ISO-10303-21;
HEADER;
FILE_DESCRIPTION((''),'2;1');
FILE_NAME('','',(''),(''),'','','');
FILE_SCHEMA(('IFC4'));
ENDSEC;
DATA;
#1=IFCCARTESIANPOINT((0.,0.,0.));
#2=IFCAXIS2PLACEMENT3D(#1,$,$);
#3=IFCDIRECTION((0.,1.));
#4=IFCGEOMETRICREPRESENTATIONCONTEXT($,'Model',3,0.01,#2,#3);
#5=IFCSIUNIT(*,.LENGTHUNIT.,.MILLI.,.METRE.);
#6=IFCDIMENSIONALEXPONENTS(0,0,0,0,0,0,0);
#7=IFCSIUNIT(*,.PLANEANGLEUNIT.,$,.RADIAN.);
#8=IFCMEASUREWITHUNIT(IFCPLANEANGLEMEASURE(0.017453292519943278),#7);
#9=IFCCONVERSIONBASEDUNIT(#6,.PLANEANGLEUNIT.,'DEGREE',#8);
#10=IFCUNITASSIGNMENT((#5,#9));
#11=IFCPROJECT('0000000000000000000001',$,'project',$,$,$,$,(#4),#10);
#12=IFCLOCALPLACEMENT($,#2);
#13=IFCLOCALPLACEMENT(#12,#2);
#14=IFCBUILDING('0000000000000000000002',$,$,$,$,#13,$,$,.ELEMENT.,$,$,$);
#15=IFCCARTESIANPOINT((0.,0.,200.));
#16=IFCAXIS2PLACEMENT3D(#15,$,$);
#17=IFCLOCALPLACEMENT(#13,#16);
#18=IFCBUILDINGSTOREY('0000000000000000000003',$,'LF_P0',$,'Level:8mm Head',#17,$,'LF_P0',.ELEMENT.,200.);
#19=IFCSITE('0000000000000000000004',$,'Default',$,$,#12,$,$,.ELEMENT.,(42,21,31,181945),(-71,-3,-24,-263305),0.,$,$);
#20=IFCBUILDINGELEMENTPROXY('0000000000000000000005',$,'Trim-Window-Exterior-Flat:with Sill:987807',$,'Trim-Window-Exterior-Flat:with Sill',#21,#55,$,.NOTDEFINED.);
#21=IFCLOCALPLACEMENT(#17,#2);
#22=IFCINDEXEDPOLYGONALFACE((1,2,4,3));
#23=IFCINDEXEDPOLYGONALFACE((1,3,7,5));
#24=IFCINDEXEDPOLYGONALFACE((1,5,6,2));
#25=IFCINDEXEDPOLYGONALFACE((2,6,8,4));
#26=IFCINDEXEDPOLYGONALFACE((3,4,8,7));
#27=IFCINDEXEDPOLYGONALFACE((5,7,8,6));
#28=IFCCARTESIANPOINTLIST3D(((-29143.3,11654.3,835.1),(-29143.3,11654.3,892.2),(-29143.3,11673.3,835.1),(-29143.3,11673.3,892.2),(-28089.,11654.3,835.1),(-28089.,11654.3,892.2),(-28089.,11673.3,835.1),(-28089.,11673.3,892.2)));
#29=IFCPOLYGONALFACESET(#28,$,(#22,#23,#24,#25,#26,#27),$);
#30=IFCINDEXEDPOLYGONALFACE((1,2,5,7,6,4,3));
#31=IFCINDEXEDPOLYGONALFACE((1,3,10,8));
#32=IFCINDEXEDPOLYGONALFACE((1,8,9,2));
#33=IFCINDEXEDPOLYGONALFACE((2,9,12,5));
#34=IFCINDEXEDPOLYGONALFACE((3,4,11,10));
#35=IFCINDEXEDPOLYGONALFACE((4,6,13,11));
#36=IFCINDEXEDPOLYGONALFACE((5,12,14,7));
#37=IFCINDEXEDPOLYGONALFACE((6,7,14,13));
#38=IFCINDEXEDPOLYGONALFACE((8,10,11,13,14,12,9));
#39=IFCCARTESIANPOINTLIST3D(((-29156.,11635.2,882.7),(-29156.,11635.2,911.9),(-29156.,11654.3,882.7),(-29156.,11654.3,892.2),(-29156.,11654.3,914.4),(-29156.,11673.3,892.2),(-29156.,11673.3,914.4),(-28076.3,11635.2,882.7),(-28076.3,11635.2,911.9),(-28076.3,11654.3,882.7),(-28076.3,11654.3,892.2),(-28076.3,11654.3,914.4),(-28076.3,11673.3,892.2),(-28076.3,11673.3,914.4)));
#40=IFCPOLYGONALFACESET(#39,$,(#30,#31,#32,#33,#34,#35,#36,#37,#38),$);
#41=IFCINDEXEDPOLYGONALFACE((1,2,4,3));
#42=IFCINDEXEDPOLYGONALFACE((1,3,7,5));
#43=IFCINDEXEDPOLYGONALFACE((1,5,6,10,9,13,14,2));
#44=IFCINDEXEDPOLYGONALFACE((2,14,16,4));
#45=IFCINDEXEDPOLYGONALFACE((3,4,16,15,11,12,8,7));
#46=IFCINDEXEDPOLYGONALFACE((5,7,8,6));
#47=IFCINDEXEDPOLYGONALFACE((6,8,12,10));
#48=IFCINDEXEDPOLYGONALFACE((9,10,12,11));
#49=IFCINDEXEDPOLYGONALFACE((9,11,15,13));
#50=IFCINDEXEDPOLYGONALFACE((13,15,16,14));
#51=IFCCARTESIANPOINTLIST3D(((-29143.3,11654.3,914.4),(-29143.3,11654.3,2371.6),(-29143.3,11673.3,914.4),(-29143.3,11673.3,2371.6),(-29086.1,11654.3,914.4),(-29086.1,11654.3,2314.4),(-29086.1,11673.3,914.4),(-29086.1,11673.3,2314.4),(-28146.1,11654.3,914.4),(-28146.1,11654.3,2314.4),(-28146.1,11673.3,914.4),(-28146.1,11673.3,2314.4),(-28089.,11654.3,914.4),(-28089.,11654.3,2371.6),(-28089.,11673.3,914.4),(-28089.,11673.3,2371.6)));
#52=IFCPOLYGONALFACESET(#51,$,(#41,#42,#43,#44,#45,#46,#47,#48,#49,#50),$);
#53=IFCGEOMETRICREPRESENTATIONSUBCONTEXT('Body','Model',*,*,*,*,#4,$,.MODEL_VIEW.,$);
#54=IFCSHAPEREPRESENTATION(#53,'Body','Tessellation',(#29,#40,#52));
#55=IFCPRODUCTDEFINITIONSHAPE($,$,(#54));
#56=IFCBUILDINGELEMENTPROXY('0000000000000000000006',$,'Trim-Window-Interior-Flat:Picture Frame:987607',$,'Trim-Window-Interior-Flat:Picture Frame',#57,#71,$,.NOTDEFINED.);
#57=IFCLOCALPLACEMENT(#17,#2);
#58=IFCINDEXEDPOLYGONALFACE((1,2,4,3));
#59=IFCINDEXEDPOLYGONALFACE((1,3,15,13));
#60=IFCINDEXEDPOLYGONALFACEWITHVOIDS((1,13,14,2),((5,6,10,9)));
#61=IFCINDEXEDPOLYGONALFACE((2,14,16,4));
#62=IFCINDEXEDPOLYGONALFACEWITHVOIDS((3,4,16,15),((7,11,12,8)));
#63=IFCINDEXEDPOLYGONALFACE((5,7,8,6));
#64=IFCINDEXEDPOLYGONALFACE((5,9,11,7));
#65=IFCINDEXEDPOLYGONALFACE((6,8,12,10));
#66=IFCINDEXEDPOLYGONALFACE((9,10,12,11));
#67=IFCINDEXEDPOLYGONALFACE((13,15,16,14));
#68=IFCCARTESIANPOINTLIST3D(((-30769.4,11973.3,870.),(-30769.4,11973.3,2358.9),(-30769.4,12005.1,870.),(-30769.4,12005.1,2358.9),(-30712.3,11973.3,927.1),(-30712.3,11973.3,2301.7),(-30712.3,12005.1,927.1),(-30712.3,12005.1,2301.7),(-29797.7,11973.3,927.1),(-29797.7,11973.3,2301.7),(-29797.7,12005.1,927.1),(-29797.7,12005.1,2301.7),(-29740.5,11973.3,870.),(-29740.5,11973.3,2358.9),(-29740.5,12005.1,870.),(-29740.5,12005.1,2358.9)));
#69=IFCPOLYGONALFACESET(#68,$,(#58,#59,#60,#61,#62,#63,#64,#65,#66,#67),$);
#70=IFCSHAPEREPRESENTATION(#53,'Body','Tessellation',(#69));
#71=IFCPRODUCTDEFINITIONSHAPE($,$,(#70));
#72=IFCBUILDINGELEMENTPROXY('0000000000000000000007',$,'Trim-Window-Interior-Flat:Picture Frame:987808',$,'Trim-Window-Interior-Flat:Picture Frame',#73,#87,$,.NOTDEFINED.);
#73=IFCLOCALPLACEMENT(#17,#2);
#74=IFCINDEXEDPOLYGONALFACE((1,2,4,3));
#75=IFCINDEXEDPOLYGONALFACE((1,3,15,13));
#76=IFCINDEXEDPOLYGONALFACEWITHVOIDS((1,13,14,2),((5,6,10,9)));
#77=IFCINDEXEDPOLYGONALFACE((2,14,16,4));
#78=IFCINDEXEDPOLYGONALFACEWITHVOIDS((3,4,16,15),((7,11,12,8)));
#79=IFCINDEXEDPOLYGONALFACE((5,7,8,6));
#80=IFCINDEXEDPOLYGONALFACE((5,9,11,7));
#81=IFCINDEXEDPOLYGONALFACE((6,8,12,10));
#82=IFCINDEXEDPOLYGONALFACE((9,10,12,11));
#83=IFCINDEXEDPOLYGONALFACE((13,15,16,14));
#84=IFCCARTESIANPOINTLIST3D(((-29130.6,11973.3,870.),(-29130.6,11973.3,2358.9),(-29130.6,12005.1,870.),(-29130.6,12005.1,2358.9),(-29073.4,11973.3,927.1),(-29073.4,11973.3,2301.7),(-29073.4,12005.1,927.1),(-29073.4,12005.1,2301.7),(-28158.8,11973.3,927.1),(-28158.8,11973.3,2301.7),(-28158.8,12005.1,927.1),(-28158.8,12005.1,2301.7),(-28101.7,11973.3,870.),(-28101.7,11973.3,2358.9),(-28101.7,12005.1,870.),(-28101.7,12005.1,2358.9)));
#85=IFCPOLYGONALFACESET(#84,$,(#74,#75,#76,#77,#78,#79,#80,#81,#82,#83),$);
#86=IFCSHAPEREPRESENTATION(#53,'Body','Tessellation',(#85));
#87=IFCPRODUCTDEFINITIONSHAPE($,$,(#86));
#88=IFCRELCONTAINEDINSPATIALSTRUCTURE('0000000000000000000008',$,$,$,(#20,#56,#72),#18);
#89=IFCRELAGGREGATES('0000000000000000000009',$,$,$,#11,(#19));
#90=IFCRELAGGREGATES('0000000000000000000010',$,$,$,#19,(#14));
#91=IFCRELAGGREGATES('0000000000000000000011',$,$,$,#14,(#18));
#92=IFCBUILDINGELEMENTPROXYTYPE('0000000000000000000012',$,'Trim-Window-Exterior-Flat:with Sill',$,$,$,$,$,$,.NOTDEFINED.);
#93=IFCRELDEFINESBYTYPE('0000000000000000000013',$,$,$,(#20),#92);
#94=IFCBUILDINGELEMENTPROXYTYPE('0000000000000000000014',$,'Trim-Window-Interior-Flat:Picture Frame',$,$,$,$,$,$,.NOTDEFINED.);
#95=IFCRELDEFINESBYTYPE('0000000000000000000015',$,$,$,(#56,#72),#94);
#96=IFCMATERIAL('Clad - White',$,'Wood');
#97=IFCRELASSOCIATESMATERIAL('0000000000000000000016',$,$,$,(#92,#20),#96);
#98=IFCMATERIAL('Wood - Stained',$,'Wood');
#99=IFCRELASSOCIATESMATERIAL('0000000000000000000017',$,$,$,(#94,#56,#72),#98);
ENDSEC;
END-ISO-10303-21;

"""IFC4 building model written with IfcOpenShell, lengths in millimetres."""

from ifc_helpers import new_model, entity, si_unit, converted_unit, direction, frame, origin, place, context, subcontext, project, spatial, indexed_curve, outline, extrude, source, transform, mapped, material, type_object, type_shapes, element, save


model = new_model("IFC4")

# Units and contexts
model_context = context("Model", 3, precision=0.01, world=origin(), true_north=direction((0.0, 1.0)))
body_context = subcontext(model_context, "Body", "Model", "MODEL_VIEW")
ifc_project = project(units=[si_unit("LENGTHUNIT", "METRE", prefix="MILLI"), converted_unit("PLANEANGLEUNIT", "DEGREE", entity("IfcPlaneAngleMeasure", 0.017453292519943278), si_unit("PLANEANGLEUNIT", "RADIAN"), dimensions=[0, 0, 0, 0, 0, 0, 0])], contexts=[model_context])

# Site, building, storey
site_placement = place(None, origin())
site = spatial("IfcSite", under=ifc_project, at=site_placement, Name="Default", CompositionType="ELEMENT", RefLatitude=(42, 21, 31, 181945), RefLongitude=(-71, -3, -24, -263305), RefElevation=0.0)
building_placement = place(site_placement, origin())
building = spatial("IfcBuilding", under=site, at=building_placement, CompositionType="ELEMENT")
storey_placement = place(building_placement, frame((0.0, 0.0, 200.0)))
storey = spatial("IfcBuildingStorey", under=building, at=storey_placement, Name="LF_P0", ObjectType="Level:8mm Head", LongName="LF_P0", CompositionType="ELEMENT", Elevation=200.0)

# Building element proxies
ifc_material_1 = material(Name="Clad - White", Category="Wood")
ifc_material_2 = material(Name="Wood - Stained", Category="Wood")
building_element_proxy_type_1 = type_object("IfcBuildingElementProxyType", Name="Trim-Window-Exterior-Flat:with Sill", PredefinedType="NOTDEFINED", material=ifc_material_1)
shared_shape_1 = source(origin(), body_context, "Body", "SweptSolid", [
    extrude(outline(indexed_curve([(-527.1, -28.6), (527.1, -28.6), (527.1, 28.6), (-527.1, 28.6), (-527.1, -28.6)], self_intersect=False)), frame((0.0, -1450.8, 0.0), z_axis=(0.0, 0.0, 1.0), x_axis=(-1.0, 0.0, 0.0)), (0.0, 0.0, 1.0), 19.0),
    extrude(outline(indexed_curve([(-19.0, -16.0), (0.0, -16.0), (0.0, -6.4), (19.0, -6.4), (19.0, 15.8), (0.0, 15.8), (-19.0, 13.3), (-19.0, -16.0)], self_intersect=False)), frame((-539.8, -1415.8, 19.0), z_axis=(1.0, 0.0, 0.0), x_axis=(0.0, 0.0, -1.0)), (0.0, 0.0, 1.0), 1079.7),
    extrude(outline(indexed_curve([(-742.9, -527.1), (714.3, -527.1), (714.3, -470.0), (-685.7, -470.0), (-685.7, 470.0), (714.3, 470.0), (714.3, 527.1), (-742.9, 527.1), (-742.9, -527.1)], self_intersect=False)), frame((0.0, -685.7, 0.0), z_axis=(0.0, 0.0, 1.0), x_axis=(0.0, -1.0, 0.0)), (0.0, 0.0, 1.0), 19.0),
])
type_shapes(building_element_proxy_type_1, [shared_shape_1])
for number, where, z_axis, x_axis, name in (
    (1, (-28616.1, 11673.3, 2314.4), (0.0, -1.0, 0.0), (1.0, 0.0, 0.0), "Trim-Window-Exterior-Flat:with Sill:987807"),
):
    element("IfcBuildingElementProxy", number, at=place(storey_placement, frame(where, z_axis=z_axis, x_axis=x_axis)), inside=storey, type_object=building_element_proxy_type_1, material=ifc_material_1, Name=name, ObjectType="Trim-Window-Exterior-Flat:with Sill", PredefinedType="NOTDEFINED", context=body_context, shape_type="MappedRepresentation", body=[
        mapped(shared_shape_1, transform((0.0, 0.0, 0.0), scale=1.0)),
    ])
building_element_proxy_type_2 = type_object("IfcBuildingElementProxyType", Name="Trim-Window-Interior-Flat:Picture Frame", PredefinedType="NOTDEFINED", material=ifc_material_2)
shared_shape_2 = source(origin(), body_context, "Body", "SweptSolid", [
    extrude(outline(indexed_curve([(-514.4, -744.4), (514.4, -744.4), (514.4, 744.4), (-514.4, 744.4), (-514.4, -744.4)], self_intersect=False), holes=[indexed_curve([(-457.3, -687.3), (-457.3, 687.3), (457.3, 687.3), (457.3, -687.3), (-457.3, -687.3)], self_intersect=False)]), frame((0.0, -700.0, 0.0), z_axis=(0.0, 0.0, 1.0), x_axis=(-1.0, 0.0, 0.0)), (0.0, 0.0, 1.0), 31.7),
])
type_shapes(building_element_proxy_type_2, [shared_shape_2])
for number, where, z_axis, x_axis, name in (
    (2, (-30255.0, 11973.3, 2314.4), (0.0, 1.0, 0.0), (-1.0, 0.0, 0.0), "Trim-Window-Interior-Flat:Picture Frame:987607"),
    (3, (-28616.1, 11973.3, 2314.4), (0.0, 1.0, 0.0), (-1.0, 0.0, 0.0), "Trim-Window-Interior-Flat:Picture Frame:987808"),
):
    element("IfcBuildingElementProxy", number, at=place(storey_placement, frame(where, z_axis=z_axis, x_axis=x_axis)), inside=storey, type_object=building_element_proxy_type_2, material=ifc_material_2, Name=name, ObjectType="Trim-Window-Interior-Flat:Picture Frame", PredefinedType="NOTDEFINED", context=body_context, shape_type="MappedRepresentation", body=[
        mapped(shared_shape_2, transform((0.0, 0.0, 0.0), scale=1.0)),
    ])

save(model, "model.ifc")
